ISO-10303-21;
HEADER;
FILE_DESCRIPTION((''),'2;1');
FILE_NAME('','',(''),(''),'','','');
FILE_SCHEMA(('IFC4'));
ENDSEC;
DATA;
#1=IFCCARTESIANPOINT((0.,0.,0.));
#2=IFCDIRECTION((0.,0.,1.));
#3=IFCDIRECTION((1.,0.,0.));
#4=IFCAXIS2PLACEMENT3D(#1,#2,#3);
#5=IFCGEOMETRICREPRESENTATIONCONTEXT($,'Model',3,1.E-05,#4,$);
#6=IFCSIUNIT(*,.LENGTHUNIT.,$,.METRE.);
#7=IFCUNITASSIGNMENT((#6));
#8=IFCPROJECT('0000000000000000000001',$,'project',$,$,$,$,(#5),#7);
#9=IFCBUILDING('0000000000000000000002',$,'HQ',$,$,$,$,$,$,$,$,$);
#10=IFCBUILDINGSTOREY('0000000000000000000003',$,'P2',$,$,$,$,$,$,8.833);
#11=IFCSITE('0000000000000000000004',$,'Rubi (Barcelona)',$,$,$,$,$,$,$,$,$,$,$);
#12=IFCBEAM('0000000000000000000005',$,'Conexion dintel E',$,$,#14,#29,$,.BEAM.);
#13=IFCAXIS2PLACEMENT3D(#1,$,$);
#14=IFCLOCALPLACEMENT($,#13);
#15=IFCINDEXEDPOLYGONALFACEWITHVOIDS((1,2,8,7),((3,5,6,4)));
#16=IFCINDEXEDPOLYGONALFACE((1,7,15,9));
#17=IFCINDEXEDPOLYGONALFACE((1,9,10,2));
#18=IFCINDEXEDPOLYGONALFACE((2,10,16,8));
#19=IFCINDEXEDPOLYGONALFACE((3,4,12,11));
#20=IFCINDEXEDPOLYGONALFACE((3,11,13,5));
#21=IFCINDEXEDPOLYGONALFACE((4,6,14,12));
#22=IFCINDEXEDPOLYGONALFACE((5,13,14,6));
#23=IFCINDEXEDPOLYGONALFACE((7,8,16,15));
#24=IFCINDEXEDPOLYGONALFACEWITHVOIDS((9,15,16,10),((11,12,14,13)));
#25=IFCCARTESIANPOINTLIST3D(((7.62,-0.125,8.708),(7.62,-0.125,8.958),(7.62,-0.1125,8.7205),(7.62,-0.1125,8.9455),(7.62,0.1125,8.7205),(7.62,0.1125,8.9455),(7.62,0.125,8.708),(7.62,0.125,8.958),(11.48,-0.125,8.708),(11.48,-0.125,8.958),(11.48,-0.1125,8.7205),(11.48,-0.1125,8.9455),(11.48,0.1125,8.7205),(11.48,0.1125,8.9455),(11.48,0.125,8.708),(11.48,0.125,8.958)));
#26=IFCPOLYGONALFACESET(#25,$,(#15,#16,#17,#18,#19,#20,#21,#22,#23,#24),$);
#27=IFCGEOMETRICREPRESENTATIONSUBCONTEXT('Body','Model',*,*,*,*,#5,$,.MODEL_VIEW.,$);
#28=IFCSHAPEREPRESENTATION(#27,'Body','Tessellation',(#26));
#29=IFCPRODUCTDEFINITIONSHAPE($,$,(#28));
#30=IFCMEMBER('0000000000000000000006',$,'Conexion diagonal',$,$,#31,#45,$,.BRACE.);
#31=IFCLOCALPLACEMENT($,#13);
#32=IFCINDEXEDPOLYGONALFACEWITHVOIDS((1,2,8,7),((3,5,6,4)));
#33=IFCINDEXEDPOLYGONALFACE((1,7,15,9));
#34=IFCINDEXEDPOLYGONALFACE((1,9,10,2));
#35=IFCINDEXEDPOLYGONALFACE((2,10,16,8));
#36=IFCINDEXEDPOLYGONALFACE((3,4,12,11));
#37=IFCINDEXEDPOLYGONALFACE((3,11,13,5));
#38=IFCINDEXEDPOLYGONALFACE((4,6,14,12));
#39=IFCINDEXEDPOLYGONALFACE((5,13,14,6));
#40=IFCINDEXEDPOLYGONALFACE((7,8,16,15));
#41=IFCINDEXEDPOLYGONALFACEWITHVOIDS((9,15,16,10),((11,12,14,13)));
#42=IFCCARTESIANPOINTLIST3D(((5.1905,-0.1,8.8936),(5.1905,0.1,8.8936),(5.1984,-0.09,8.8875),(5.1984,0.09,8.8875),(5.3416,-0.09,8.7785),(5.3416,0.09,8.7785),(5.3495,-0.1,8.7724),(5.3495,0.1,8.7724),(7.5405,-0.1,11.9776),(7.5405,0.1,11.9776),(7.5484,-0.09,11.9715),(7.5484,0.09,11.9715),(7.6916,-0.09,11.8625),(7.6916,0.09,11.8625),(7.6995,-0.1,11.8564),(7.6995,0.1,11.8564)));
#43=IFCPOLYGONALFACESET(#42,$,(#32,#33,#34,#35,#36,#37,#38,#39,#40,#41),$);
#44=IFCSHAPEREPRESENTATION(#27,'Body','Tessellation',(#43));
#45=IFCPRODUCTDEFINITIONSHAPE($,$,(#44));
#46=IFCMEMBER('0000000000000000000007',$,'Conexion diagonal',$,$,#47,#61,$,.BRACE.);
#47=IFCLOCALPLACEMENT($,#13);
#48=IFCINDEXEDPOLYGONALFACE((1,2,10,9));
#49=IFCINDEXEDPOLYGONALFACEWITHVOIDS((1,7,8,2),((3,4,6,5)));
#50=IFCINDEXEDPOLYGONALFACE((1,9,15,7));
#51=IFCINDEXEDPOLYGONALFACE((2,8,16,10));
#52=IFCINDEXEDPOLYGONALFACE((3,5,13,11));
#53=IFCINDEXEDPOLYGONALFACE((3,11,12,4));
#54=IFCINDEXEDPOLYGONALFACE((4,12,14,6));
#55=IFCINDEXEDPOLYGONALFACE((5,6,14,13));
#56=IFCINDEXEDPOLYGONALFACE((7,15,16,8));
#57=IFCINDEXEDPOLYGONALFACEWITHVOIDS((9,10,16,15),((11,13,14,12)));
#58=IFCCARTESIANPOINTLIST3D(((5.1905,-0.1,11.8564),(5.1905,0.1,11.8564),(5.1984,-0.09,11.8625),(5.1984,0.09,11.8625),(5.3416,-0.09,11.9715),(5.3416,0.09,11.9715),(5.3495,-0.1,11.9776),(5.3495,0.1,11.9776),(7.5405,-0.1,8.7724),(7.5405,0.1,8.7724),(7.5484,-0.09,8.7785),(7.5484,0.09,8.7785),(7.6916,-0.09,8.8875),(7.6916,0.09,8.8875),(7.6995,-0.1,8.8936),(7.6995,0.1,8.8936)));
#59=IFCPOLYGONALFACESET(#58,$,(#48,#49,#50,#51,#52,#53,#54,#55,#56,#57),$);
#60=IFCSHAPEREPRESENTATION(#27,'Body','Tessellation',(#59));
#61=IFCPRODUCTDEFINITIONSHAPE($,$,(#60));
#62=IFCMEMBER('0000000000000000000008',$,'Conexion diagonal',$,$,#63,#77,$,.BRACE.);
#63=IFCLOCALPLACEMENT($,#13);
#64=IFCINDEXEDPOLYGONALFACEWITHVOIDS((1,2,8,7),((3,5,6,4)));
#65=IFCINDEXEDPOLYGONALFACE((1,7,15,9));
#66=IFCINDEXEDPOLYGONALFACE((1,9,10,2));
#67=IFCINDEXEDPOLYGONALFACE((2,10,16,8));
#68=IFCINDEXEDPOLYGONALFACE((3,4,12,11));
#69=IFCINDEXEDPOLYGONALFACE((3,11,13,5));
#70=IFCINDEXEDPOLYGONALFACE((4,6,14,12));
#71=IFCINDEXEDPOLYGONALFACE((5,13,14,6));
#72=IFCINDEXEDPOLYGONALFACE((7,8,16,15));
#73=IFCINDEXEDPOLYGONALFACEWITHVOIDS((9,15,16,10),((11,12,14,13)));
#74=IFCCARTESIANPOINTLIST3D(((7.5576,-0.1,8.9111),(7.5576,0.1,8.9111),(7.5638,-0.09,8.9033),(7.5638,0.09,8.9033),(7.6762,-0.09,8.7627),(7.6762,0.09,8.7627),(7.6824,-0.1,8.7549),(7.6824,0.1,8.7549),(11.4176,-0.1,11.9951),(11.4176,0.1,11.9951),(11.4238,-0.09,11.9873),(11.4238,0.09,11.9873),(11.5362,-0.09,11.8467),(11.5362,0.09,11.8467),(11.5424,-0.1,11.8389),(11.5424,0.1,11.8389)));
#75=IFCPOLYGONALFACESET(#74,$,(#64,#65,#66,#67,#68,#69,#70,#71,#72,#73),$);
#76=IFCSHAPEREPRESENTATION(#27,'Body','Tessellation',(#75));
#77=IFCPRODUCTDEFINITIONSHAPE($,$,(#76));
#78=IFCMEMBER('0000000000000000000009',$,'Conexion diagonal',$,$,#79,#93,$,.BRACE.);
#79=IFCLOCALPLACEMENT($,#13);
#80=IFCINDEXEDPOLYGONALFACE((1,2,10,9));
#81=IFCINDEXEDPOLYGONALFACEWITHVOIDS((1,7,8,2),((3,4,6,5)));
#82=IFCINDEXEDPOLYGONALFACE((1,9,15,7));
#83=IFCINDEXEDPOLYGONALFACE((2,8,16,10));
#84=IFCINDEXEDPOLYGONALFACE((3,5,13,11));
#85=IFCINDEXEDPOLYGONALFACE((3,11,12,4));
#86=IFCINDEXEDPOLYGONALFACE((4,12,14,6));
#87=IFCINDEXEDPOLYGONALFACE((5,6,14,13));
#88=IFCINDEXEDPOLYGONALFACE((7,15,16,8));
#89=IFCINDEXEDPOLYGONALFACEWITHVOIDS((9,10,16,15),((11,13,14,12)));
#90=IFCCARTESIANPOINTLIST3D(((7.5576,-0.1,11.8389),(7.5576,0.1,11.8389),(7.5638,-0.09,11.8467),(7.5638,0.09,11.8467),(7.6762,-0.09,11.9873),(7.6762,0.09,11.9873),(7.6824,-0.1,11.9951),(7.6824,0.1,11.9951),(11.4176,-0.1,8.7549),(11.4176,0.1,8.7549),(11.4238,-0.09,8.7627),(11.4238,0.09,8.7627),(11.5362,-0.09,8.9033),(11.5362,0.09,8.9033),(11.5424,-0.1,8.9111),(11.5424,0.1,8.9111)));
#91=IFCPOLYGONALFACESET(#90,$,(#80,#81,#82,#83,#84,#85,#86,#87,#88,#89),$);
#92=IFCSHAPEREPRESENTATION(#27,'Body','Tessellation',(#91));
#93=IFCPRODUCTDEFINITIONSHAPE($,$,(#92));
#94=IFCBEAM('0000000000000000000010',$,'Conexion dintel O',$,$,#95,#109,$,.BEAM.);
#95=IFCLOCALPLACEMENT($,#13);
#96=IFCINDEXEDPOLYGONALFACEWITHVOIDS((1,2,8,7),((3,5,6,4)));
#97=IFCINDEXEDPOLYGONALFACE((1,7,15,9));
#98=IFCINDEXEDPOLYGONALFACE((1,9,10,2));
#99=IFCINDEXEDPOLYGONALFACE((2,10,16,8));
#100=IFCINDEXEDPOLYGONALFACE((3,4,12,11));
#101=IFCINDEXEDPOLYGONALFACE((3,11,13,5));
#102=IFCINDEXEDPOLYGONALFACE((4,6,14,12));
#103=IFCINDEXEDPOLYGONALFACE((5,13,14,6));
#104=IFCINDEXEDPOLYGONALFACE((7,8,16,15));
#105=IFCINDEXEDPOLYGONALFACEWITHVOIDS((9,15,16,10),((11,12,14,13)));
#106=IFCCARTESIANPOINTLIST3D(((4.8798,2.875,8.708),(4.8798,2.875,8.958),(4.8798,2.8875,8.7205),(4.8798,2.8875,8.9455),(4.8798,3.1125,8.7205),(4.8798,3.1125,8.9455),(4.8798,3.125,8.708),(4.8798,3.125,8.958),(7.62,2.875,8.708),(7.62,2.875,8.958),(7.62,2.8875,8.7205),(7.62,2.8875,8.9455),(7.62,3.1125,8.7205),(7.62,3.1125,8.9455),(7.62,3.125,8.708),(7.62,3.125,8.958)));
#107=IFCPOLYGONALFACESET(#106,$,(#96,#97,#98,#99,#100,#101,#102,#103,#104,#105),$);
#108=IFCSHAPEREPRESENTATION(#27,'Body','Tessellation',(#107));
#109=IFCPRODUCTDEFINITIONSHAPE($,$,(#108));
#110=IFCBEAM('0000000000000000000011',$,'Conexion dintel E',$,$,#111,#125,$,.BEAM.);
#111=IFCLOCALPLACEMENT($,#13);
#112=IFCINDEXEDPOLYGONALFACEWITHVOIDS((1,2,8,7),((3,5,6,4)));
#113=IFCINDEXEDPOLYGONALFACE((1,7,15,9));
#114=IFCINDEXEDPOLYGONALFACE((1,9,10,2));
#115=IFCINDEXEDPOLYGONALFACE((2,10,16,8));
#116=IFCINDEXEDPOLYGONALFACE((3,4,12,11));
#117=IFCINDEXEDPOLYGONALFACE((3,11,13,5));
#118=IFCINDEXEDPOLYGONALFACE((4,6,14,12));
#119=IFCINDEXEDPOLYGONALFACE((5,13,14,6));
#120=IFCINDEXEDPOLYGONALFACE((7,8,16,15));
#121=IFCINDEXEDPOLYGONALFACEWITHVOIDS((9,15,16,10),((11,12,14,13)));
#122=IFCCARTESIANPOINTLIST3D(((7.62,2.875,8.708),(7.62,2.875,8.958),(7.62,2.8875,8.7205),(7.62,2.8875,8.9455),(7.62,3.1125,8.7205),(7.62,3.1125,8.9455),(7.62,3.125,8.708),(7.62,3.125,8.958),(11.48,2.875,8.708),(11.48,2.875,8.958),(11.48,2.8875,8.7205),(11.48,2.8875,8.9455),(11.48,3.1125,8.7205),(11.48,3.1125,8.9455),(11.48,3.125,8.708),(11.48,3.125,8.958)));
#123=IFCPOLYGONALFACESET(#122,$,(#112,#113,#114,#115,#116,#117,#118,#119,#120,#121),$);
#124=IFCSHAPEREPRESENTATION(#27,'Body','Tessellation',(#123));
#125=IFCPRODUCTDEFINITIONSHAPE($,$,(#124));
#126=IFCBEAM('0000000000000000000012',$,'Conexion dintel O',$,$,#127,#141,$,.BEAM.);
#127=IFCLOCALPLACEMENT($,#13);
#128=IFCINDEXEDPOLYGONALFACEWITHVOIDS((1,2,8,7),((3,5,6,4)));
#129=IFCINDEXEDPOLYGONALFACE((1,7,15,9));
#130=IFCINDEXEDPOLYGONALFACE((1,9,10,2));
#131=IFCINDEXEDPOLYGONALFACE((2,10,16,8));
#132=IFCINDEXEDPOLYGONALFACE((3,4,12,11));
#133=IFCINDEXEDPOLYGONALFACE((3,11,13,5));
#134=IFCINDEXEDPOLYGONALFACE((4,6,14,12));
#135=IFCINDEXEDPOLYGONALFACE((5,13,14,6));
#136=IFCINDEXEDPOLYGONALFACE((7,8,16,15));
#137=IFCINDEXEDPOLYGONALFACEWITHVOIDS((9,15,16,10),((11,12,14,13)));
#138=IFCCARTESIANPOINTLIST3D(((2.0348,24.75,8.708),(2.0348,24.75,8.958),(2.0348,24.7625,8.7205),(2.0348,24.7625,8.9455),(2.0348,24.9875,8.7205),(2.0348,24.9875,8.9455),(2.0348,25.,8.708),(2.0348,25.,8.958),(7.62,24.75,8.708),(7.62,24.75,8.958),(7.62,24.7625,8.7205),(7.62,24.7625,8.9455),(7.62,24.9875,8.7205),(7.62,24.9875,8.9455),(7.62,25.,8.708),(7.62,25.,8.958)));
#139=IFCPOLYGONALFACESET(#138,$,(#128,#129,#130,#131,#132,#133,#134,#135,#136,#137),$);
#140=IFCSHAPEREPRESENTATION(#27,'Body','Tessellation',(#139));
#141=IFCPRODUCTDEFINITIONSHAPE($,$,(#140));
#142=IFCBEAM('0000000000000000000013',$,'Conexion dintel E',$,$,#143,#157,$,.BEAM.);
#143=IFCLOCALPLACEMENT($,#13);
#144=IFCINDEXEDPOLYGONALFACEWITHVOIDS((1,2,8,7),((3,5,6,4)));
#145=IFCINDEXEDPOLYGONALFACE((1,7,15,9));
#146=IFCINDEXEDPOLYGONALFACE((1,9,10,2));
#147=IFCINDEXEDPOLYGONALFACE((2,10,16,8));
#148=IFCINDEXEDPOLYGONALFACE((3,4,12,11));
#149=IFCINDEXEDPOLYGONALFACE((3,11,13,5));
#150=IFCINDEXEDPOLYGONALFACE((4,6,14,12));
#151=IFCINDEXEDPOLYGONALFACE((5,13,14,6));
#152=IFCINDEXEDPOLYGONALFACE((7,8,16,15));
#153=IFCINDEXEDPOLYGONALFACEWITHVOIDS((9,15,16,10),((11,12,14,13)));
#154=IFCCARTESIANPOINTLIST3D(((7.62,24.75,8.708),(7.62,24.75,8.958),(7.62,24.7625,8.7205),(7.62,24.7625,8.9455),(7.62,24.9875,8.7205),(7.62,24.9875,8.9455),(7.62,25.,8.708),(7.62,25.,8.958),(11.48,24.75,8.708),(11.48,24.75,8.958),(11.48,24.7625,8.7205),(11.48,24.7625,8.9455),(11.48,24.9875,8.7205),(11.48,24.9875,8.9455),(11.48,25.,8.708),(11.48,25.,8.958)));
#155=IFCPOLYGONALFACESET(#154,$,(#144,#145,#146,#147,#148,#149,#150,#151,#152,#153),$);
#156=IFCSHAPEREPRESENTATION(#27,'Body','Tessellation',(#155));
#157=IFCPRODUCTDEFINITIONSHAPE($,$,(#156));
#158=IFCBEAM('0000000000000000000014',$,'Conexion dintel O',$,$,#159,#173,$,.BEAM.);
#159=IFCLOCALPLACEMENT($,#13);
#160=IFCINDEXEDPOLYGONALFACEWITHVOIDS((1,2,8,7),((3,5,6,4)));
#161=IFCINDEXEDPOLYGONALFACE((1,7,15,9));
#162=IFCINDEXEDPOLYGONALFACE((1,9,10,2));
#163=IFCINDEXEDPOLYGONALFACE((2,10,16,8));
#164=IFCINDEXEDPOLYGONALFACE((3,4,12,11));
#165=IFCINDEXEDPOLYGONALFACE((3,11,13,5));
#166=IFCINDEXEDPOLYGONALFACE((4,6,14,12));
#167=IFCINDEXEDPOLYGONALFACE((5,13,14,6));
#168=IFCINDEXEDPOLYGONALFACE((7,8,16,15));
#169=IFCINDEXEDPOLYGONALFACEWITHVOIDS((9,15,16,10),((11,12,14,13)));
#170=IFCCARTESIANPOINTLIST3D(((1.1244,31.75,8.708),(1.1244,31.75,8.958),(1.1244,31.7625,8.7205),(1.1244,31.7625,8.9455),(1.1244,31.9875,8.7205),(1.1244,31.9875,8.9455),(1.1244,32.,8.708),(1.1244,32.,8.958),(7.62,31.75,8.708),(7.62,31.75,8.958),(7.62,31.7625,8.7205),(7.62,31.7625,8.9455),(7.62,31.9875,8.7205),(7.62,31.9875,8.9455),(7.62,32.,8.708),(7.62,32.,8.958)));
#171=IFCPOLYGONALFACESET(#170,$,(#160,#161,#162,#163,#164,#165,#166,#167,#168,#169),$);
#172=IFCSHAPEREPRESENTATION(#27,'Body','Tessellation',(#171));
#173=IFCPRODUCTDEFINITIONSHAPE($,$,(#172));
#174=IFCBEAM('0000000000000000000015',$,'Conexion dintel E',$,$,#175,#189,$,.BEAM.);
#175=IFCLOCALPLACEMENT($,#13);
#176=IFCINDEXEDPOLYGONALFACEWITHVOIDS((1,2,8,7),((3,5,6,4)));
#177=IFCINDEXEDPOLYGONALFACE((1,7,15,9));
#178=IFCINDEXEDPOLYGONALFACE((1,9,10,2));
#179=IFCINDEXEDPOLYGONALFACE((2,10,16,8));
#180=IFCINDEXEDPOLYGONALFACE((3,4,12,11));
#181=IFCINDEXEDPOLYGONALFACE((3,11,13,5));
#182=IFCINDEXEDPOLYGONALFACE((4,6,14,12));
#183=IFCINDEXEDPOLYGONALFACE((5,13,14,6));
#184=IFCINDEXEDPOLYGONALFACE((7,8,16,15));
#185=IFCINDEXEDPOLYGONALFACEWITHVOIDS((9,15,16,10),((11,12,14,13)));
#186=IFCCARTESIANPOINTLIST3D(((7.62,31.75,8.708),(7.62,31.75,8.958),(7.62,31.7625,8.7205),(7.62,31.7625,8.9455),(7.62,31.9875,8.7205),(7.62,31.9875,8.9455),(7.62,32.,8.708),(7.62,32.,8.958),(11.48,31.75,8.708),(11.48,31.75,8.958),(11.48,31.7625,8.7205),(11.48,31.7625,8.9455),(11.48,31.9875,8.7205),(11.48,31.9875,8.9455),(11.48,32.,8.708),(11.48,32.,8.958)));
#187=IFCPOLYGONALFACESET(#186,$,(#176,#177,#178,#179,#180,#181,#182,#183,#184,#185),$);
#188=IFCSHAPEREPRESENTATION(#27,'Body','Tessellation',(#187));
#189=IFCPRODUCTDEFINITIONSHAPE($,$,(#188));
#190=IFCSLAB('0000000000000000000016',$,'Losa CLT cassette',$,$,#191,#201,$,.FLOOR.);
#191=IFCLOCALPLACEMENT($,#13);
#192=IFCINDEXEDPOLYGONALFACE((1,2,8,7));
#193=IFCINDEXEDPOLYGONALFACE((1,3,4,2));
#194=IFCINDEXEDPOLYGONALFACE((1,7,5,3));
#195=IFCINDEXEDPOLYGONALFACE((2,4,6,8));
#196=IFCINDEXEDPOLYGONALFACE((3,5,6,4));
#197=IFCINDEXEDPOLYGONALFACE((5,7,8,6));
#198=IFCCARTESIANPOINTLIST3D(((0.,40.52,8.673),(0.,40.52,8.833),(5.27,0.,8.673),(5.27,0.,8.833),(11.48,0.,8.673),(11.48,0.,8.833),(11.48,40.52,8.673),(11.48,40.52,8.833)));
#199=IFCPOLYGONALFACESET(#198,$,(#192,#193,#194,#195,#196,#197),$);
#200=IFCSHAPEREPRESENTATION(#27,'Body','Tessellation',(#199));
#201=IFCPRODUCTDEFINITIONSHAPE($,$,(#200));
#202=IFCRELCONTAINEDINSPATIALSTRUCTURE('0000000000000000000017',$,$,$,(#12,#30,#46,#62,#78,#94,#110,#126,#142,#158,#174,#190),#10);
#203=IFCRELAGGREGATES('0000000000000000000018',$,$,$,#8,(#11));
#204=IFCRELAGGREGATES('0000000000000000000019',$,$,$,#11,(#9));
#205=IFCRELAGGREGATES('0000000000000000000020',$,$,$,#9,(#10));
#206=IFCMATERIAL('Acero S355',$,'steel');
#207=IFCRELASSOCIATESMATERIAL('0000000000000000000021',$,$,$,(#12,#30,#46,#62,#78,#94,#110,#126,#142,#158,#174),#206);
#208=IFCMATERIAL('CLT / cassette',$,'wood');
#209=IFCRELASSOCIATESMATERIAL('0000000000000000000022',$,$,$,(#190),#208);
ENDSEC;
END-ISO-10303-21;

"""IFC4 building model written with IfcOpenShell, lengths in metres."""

from ifc_helpers import new_model, si_unit, frame, origin_with_axes, place, context, subcontext, project, spatial, polyline, hollow_rectangle, outline, extrude, material, element, save


model = new_model("IFC4")

# Units and contexts
model_context = context("Model", 3, precision=1e-05, world=origin_with_axes())
body_context = subcontext(model_context, "Body", "Model", "MODEL_VIEW")
ifc_project = project(units=[si_unit("LENGTHUNIT", "METRE")], contexts=[model_context])

# Site, building, storey
site = spatial("IfcSite", under=ifc_project, Name="Rubi (Barcelona)")
building = spatial("IfcBuilding", under=site, Name="HQ")
storey = spatial("IfcBuildingStorey", under=building, Name="P2", Elevation=8.833)

# Beam
ifc_material_1 = material(Name="Acero S355", Category="steel")
beam_1_placement = place(None, origin_with_axes())
element("IfcBeam", 1, at=beam_1_placement, inside=storey, material=ifc_material_1, Name="Conexion dintel E", PredefinedType="BEAM", context=body_context, shape_type="SweptSolid", body=[
    extrude(hollow_rectangle(XDim=0.25, YDim=0.25, WallThickness=0.0125), frame((7.62, 0.0, 8.833), z_axis=(1.0, 0.0, 0.0), x_axis=(0.0, 1.0, 0.0)), (0.0, 0.0, 1.0), 3.86),
])

# Members
member_1_placement = place(None, origin_with_axes())
element("IfcMember", 2, at=member_1_placement, inside=storey, material=ifc_material_1, Name="Conexion diagonal", PredefinedType="BRACE", context=body_context, shape_type="SweptSolid", body=[
    extrude(hollow_rectangle(XDim=0.2, YDim=0.2, WallThickness=0.01), frame((5.27, 0.0, 8.833), z_axis=(0.60609, 0.0, 0.795396), x_axis=(0.0, 1.0, 0.0)), (0.0, 0.0, 1.0), 3.8773),
])
member_2_placement = place(None, origin_with_axes())
element("IfcMember", 3, at=member_2_placement, inside=storey, material=ifc_material_1, Name="Conexion diagonal", PredefinedType="BRACE", context=body_context, shape_type="SweptSolid", body=[
    extrude(hollow_rectangle(XDim=0.2, YDim=0.2, WallThickness=0.01), frame((7.62, 0.0, 8.833), z_axis=(-0.60609, 0.0, 0.795396), x_axis=(0.0, -1.0, 0.0)), (0.0, 0.0, 1.0), 3.8773),
])
member_3_placement = place(None, origin_with_axes())
element("IfcMember", 4, at=member_3_placement, inside=storey, material=ifc_material_1, Name="Conexion diagonal", PredefinedType="BRACE", context=body_context, shape_type="SweptSolid", body=[
    extrude(hollow_rectangle(XDim=0.2, YDim=0.2, WallThickness=0.01), frame((7.62, 0.0, 8.833), z_axis=(0.781264, 0.0, 0.624201), x_axis=(0.0, 1.0, 0.0)), (0.0, 0.0, 1.0), 4.9407),
])
member_4_placement = place(None, origin_with_axes())
element("IfcMember", 5, at=member_4_placement, inside=storey, material=ifc_material_1, Name="Conexion diagonal", PredefinedType="BRACE", context=body_context, shape_type="SweptSolid", body=[
    extrude(hollow_rectangle(XDim=0.2, YDim=0.2, WallThickness=0.01), frame((11.48, 0.0, 8.833), z_axis=(-0.781264, 0.0, 0.624201), x_axis=(0.0, -1.0, 0.0)), (0.0, 0.0, 1.0), 4.9407),
])

# Beams
beam_2_placement = place(None, origin_with_axes())
element("IfcBeam", 6, at=beam_2_placement, inside=storey, material=ifc_material_1, Name="Conexion dintel O", PredefinedType="BEAM", context=body_context, shape_type="SweptSolid", body=[
    extrude(hollow_rectangle(XDim=0.25, YDim=0.25, WallThickness=0.0125), frame((4.8798, 3.0, 8.833), z_axis=(1.0, 0.0, 0.0), x_axis=(0.0, 1.0, 0.0)), (0.0, 0.0, 1.0), 2.7402),
])
beam_3_placement = place(None, origin_with_axes())
element("IfcBeam", 7, at=beam_3_placement, inside=storey, material=ifc_material_1, Name="Conexion dintel E", PredefinedType="BEAM", context=body_context, shape_type="SweptSolid", body=[
    extrude(hollow_rectangle(XDim=0.25, YDim=0.25, WallThickness=0.0125), frame((7.62, 3.0, 8.833), z_axis=(1.0, 0.0, 0.0), x_axis=(0.0, 1.0, 0.0)), (0.0, 0.0, 1.0), 3.86),
])
beam_4_placement = place(None, origin_with_axes())
element("IfcBeam", 8, at=beam_4_placement, inside=storey, material=ifc_material_1, Name="Conexion dintel O", PredefinedType="BEAM", context=body_context, shape_type="SweptSolid", body=[
    extrude(hollow_rectangle(XDim=0.25, YDim=0.25, WallThickness=0.0125), frame((2.0348, 24.875, 8.833), z_axis=(1.0, 0.0, 0.0), x_axis=(0.0, 1.0, 0.0)), (0.0, 0.0, 1.0), 5.5852),
])
beam_5_placement = place(None, origin_with_axes())
element("IfcBeam", 9, at=beam_5_placement, inside=storey, material=ifc_material_1, Name="Conexion dintel E", PredefinedType="BEAM", context=body_context, shape_type="SweptSolid", body=[
    extrude(hollow_rectangle(XDim=0.25, YDim=0.25, WallThickness=0.0125), frame((7.62, 24.875, 8.833), z_axis=(1.0, 0.0, 0.0), x_axis=(0.0, 1.0, 0.0)), (0.0, 0.0, 1.0), 3.86),
])
beam_6_placement = place(None, origin_with_axes())
element("IfcBeam", 10, at=beam_6_placement, inside=storey, material=ifc_material_1, Name="Conexion dintel O", PredefinedType="BEAM", context=body_context, shape_type="SweptSolid", body=[
    extrude(hollow_rectangle(XDim=0.25, YDim=0.25, WallThickness=0.0125), frame((1.1244, 31.875, 8.833), z_axis=(1.0, 0.0, 0.0), x_axis=(0.0, 1.0, 0.0)), (0.0, 0.0, 1.0), 6.4956),
])
beam_7_placement = place(None, origin_with_axes())
element("IfcBeam", 11, at=beam_7_placement, inside=storey, material=ifc_material_1, Name="Conexion dintel E", PredefinedType="BEAM", context=body_context, shape_type="SweptSolid", body=[
    extrude(hollow_rectangle(XDim=0.25, YDim=0.25, WallThickness=0.0125), frame((7.62, 31.875, 8.833), z_axis=(1.0, 0.0, 0.0), x_axis=(0.0, 1.0, 0.0)), (0.0, 0.0, 1.0), 3.86),
])

# Slab
ifc_material_2 = material(Name="CLT / cassette", Category="wood")
slab_placement = place(None, origin_with_axes())
element("IfcSlab", 12, at=slab_placement, inside=storey, material=ifc_material_2, Name="Losa CLT cassette", PredefinedType="FLOOR", context=body_context, shape_type="SweptSolid", body=[
    extrude(outline(polyline([(5.27, 0.0, 0.0), (11.48, 0.0, 0.0), (11.48, 40.52, 0.0), (0.0, 40.52, 0.0), (5.27, 0.0, 0.0)])), frame((0.0, 0.0, 8.673)), (0.0, 0.0, 1.0), 0.16),
])

save(model, "model.ifc")
